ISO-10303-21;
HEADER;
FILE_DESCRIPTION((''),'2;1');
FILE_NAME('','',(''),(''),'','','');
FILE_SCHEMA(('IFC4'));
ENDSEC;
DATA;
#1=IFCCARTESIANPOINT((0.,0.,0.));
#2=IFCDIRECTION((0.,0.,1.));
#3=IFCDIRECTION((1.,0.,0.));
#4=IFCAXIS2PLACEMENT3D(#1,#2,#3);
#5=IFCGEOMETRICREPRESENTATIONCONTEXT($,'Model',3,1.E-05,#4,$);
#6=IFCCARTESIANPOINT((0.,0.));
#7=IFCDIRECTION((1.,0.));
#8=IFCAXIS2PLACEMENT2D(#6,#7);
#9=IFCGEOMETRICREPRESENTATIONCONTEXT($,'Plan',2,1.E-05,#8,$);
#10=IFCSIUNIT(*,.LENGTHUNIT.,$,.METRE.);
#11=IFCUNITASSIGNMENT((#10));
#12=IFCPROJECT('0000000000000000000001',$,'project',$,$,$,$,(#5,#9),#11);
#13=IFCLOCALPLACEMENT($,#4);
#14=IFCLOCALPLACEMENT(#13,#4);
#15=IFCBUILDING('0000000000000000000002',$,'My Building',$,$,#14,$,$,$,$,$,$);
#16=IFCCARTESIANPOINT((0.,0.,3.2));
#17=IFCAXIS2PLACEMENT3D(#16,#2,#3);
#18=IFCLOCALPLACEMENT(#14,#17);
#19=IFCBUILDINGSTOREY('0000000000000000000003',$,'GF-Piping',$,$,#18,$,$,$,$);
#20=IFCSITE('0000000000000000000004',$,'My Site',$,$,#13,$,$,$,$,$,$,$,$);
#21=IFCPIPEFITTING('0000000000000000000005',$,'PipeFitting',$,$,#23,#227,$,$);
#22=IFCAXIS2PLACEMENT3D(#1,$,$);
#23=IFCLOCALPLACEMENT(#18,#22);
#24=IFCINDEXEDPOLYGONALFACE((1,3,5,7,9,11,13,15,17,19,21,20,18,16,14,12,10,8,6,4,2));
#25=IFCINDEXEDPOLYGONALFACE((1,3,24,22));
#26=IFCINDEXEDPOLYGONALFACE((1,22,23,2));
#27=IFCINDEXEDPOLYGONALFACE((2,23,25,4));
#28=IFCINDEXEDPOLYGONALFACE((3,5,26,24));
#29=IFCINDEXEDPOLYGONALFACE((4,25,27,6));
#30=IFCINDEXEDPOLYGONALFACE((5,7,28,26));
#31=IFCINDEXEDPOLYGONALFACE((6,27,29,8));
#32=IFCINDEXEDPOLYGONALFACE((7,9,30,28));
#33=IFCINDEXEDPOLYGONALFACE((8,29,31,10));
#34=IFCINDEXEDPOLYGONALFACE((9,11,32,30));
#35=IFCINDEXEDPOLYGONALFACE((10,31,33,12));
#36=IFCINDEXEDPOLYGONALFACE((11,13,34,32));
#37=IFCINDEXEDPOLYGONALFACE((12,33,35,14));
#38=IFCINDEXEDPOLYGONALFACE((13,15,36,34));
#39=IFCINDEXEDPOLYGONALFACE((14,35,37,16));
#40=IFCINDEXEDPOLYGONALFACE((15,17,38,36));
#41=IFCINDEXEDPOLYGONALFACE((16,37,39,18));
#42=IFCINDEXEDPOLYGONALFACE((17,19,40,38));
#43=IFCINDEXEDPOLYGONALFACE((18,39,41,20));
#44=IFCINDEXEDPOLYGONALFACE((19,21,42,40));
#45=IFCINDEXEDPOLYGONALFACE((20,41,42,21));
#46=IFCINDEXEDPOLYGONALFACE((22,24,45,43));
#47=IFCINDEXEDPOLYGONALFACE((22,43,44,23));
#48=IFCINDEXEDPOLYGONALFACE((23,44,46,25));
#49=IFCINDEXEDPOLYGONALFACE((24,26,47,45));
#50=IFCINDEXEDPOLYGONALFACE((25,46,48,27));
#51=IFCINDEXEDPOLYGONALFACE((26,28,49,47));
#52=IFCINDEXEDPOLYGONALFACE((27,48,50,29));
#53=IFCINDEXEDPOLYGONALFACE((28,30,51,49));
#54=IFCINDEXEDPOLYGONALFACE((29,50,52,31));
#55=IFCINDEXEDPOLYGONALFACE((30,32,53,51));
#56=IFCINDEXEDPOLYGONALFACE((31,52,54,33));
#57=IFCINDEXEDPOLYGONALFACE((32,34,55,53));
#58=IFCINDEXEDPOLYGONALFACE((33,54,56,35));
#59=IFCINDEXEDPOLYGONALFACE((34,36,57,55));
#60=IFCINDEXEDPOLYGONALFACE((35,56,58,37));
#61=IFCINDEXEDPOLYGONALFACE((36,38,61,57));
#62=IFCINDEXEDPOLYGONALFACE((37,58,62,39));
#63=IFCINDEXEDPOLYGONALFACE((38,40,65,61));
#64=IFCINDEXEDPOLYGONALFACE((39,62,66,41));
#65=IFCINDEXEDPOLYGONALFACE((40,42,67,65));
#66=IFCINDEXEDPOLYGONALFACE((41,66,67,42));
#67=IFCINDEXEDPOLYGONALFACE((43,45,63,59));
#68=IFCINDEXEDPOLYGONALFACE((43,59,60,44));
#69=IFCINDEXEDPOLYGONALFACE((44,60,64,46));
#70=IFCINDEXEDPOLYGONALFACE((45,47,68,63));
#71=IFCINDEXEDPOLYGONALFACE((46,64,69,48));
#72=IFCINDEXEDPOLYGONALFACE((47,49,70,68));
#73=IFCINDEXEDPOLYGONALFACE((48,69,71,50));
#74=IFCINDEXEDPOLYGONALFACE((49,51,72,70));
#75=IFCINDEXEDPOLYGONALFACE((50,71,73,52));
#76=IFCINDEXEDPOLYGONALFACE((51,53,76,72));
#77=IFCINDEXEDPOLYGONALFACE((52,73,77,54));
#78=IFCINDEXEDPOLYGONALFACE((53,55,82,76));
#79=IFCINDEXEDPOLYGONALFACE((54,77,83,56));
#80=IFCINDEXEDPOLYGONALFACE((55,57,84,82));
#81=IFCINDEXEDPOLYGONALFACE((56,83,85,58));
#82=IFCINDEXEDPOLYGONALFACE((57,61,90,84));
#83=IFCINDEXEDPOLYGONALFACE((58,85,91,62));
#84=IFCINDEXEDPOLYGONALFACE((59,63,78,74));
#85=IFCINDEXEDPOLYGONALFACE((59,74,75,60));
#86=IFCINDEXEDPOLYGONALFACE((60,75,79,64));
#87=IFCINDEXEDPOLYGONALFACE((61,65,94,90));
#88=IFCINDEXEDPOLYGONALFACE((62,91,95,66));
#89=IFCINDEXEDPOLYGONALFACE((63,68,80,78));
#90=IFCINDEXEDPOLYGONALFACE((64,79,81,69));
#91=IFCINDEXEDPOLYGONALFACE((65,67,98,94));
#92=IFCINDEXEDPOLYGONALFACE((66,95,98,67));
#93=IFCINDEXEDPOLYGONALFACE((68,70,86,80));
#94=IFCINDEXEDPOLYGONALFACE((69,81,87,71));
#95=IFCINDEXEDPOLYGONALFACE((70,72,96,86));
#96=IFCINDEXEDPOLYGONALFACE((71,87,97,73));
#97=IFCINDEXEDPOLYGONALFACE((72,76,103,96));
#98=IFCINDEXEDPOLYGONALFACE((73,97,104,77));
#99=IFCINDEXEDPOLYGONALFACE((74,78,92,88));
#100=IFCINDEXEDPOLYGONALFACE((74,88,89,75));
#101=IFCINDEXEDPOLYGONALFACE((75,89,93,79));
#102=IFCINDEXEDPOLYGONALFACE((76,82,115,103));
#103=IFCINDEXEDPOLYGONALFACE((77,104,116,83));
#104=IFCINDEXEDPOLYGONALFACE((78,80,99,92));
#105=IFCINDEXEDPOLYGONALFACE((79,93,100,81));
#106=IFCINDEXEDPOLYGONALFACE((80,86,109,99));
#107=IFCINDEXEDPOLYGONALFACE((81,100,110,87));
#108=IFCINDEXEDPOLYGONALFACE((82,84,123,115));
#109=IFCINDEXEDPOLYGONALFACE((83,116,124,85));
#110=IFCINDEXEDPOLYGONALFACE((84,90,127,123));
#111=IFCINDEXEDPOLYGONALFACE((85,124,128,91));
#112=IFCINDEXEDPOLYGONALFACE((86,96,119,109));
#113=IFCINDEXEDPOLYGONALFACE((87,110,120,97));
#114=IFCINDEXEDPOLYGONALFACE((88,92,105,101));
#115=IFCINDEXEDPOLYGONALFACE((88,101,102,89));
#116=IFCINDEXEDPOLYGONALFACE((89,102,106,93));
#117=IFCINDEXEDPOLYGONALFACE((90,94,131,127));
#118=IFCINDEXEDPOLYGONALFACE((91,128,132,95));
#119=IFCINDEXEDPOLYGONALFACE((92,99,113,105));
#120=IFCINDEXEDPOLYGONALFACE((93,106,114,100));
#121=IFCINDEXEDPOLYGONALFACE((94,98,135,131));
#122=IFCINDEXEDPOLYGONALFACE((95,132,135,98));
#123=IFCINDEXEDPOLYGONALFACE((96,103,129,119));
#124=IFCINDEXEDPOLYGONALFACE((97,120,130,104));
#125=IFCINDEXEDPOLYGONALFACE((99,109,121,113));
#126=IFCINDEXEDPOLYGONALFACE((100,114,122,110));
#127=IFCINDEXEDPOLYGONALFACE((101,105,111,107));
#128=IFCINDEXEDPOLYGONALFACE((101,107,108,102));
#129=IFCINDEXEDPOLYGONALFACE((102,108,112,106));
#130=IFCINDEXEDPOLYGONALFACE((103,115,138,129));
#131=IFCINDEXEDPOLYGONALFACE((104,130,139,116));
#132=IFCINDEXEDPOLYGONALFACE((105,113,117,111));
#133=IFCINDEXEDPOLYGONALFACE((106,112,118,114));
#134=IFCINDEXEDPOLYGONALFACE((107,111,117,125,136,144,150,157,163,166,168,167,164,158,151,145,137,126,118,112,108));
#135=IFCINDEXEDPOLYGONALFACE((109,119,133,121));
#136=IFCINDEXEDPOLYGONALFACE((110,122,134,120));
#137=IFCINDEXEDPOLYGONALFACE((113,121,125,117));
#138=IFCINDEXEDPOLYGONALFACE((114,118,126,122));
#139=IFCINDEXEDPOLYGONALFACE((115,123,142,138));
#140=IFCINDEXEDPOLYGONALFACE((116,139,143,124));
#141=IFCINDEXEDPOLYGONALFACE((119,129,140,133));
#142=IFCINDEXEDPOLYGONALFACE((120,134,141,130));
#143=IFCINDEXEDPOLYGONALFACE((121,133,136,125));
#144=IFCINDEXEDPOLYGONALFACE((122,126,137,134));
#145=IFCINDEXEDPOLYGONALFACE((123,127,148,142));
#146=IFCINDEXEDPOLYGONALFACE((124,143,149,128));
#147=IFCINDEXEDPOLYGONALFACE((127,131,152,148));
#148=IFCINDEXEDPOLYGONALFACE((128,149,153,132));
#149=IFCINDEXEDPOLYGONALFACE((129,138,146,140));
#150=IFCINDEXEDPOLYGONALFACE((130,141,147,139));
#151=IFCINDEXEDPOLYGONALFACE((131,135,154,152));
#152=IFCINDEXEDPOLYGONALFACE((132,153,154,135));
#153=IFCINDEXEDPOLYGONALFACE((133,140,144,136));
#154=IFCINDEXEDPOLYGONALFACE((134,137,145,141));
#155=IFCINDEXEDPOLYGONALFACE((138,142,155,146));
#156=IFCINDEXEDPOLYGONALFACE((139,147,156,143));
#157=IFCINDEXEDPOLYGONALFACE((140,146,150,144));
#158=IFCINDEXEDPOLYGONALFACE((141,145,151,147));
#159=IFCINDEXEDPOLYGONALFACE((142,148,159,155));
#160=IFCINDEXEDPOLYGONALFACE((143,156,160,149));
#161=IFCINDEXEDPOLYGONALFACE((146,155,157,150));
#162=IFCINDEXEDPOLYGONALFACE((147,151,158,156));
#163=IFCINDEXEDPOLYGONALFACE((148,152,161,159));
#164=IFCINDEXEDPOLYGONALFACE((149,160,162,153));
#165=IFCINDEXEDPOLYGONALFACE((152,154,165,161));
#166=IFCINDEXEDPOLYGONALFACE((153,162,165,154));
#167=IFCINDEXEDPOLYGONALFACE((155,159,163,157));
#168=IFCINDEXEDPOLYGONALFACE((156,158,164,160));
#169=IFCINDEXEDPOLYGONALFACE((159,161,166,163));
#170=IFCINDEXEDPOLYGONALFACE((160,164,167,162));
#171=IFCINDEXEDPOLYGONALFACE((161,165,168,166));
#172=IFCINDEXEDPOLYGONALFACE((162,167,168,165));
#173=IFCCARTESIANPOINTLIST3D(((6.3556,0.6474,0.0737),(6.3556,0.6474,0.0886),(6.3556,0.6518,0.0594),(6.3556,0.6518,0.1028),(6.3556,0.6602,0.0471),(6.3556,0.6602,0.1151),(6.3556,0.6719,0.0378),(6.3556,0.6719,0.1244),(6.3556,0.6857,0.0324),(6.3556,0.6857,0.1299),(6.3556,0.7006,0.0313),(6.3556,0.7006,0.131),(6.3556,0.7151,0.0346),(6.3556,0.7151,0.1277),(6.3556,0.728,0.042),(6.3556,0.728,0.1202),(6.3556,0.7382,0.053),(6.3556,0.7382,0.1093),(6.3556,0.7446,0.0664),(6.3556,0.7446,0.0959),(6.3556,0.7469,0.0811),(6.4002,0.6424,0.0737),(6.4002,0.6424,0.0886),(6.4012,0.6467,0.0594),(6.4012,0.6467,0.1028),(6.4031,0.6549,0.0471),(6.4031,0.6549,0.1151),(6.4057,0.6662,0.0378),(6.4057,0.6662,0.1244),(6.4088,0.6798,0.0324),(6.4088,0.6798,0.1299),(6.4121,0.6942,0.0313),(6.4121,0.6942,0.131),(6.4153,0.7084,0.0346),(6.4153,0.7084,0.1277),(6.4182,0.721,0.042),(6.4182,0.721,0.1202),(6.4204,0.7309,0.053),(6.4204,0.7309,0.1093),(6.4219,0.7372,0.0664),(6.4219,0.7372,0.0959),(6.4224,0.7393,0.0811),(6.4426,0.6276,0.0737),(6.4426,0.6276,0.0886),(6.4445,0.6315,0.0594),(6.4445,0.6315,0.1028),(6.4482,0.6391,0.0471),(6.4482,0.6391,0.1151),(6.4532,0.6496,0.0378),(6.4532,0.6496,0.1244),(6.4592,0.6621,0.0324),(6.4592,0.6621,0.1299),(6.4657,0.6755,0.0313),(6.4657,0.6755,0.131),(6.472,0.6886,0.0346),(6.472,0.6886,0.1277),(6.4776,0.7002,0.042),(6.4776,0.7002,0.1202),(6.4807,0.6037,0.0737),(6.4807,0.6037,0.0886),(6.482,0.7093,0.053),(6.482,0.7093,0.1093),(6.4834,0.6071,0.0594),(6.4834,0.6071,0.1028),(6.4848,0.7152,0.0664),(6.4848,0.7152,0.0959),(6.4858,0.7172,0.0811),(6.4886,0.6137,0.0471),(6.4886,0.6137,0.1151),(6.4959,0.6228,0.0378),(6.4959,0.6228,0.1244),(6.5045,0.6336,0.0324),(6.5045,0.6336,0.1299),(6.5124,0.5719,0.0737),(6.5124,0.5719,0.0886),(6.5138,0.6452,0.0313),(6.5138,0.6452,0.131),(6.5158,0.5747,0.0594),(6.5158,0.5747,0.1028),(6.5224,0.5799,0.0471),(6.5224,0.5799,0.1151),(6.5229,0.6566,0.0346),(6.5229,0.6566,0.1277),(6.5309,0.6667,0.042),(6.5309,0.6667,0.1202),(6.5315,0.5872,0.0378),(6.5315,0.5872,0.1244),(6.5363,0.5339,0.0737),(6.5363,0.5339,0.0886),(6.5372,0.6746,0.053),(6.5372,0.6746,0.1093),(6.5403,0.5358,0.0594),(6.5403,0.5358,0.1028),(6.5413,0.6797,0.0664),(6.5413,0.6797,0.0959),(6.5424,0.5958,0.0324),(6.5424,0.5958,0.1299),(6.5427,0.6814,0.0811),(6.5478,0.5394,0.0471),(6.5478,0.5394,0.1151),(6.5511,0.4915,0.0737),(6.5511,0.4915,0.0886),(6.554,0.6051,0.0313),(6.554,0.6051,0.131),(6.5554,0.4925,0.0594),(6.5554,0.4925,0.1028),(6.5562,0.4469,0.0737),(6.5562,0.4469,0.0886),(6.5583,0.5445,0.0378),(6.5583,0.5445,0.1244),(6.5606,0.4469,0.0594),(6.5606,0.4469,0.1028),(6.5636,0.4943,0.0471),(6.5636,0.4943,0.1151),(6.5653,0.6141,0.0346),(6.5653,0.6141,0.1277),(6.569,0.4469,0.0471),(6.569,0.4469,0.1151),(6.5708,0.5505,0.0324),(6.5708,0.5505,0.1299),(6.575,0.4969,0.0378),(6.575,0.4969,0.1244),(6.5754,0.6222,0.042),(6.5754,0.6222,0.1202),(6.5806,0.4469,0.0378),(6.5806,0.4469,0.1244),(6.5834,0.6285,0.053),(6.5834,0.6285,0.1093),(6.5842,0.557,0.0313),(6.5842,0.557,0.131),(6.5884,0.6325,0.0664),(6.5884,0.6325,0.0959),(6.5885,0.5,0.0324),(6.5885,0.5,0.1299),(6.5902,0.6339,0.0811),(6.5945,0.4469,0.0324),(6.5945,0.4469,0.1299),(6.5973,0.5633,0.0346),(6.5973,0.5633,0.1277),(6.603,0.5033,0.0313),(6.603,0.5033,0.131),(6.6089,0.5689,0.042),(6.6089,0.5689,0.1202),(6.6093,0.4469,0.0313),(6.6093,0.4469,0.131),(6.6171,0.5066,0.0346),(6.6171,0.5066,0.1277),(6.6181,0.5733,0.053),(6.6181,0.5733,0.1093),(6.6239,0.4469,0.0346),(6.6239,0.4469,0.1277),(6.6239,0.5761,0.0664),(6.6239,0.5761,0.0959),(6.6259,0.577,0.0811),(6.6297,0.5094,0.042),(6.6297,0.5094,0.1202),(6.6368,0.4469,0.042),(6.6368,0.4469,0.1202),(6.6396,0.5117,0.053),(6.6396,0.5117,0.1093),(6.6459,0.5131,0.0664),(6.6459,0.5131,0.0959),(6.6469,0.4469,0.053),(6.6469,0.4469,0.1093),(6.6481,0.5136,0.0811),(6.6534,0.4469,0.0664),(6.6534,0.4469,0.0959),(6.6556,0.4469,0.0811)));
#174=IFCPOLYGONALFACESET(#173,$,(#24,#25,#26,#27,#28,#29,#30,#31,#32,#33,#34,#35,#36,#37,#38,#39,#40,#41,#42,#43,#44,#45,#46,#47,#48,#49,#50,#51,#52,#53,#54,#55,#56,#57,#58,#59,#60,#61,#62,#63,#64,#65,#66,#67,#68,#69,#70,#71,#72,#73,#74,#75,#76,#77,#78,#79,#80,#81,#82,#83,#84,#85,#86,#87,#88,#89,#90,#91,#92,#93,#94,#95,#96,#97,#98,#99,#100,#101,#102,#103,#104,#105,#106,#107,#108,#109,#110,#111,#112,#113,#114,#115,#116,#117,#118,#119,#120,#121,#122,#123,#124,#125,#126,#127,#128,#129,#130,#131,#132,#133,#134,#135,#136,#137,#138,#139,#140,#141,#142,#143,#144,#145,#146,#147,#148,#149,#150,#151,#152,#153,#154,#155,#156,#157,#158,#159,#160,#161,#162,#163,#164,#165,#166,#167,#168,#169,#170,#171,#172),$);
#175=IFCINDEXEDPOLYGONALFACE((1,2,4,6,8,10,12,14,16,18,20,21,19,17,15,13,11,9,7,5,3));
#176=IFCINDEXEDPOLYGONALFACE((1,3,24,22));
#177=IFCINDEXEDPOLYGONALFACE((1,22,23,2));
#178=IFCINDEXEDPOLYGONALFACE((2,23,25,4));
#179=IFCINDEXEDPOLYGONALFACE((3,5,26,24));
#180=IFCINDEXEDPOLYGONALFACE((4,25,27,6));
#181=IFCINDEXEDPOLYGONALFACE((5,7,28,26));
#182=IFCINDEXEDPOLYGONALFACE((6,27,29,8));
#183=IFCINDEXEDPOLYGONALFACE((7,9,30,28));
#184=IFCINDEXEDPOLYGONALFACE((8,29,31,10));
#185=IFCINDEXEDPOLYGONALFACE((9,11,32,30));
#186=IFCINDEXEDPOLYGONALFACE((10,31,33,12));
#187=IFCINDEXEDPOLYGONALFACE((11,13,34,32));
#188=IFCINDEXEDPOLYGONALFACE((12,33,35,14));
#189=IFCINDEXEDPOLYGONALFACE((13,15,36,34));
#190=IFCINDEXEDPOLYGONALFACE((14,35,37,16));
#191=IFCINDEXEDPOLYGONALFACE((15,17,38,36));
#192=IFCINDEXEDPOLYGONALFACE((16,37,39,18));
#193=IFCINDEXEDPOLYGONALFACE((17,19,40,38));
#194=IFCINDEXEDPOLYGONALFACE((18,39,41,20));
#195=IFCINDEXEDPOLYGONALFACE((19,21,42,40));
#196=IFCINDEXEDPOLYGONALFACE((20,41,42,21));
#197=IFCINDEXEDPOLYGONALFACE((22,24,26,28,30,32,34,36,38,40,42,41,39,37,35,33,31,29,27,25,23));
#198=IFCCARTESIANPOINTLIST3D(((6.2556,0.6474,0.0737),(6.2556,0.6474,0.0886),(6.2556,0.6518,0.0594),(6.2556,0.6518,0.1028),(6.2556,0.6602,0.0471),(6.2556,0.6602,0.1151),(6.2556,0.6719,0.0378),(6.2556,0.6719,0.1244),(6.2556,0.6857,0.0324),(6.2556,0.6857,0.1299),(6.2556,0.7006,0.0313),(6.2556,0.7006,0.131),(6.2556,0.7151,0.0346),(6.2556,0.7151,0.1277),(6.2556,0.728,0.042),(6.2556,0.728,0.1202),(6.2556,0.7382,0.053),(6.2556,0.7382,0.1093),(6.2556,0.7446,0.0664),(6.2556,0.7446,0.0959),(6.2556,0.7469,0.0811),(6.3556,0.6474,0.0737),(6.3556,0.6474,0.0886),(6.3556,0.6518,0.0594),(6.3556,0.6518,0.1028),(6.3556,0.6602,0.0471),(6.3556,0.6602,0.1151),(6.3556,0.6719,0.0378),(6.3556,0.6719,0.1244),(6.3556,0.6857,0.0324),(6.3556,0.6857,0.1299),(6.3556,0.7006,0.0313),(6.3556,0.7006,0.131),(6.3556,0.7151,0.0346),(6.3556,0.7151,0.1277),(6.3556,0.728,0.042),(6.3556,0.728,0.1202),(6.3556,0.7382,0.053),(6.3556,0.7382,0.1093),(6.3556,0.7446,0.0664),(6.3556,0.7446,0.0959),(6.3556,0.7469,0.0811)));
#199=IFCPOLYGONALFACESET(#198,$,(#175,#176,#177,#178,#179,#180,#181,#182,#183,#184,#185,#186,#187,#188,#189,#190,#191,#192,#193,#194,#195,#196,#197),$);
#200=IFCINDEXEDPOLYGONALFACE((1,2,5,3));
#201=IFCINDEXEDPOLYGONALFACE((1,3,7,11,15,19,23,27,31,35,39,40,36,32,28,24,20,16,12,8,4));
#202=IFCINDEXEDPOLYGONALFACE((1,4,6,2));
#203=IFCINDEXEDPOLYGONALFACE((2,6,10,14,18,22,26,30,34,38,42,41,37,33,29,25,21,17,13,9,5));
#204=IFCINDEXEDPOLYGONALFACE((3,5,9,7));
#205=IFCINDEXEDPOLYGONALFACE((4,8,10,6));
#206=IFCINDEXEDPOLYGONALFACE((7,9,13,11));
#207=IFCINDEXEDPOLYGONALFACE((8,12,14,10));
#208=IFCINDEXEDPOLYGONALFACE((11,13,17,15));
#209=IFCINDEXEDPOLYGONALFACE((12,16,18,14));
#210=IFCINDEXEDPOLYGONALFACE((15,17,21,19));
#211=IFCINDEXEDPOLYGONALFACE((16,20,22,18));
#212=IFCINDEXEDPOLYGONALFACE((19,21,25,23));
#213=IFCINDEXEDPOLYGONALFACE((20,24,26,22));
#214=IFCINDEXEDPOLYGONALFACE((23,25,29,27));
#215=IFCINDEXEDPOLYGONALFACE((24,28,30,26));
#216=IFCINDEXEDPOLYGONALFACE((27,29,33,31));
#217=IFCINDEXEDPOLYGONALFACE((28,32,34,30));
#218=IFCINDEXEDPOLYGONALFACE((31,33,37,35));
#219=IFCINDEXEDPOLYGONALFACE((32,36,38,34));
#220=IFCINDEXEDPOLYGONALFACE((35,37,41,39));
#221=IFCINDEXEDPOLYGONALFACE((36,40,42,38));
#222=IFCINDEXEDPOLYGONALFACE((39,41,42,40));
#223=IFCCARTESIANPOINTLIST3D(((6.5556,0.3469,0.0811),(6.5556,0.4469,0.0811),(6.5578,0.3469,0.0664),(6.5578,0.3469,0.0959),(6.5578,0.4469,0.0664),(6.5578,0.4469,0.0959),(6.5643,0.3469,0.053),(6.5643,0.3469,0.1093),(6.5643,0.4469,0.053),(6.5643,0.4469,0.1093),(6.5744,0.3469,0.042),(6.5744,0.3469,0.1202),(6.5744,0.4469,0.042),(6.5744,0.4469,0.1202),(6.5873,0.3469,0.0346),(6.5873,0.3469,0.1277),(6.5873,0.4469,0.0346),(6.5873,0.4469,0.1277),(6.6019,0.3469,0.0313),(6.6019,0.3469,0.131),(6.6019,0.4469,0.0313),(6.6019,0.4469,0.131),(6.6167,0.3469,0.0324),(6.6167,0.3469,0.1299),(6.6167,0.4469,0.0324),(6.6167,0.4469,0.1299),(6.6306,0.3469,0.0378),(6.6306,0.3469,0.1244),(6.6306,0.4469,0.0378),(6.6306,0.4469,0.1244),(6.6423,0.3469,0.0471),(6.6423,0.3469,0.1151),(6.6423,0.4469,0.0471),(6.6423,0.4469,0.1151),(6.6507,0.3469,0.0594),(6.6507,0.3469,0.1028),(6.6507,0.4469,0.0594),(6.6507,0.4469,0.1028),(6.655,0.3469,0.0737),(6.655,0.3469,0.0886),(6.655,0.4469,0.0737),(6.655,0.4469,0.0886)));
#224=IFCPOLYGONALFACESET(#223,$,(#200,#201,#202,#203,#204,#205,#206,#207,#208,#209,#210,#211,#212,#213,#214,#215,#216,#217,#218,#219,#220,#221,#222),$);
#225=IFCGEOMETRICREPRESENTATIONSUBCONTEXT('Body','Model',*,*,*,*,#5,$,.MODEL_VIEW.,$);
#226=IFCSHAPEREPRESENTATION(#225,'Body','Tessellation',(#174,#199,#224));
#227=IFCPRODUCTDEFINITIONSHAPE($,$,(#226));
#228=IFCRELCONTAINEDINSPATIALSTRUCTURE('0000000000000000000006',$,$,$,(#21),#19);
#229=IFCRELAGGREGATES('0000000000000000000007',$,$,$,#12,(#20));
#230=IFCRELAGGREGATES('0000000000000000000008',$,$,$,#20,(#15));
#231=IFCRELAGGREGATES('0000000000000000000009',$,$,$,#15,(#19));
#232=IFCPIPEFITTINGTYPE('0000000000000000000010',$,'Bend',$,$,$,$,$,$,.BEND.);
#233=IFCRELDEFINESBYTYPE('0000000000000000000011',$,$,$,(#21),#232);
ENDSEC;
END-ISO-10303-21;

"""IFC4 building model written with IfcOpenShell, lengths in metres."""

from ifc_helpers import new_model, entity, si_unit, frame, origin_with_axes, origin_2d_with_axis, place, context, subcontext, project, spatial, circle, extrude, source, transform, mapped, type_object, type_shapes, element, save


model = new_model("IFC4")

# Units and contexts
model_context = context("Model", 3, precision=1e-05, world=origin_with_axes())
plan_context = context("Plan", 2, precision=1e-05, world=origin_2d_with_axis())
body_context = subcontext(model_context, "Body", "Model", "MODEL_VIEW")
ifc_project = project(units=[si_unit("LENGTHUNIT", "METRE")], contexts=[model_context, plan_context])

# Site, building, storey
site_placement = place(None, origin_with_axes())
site = spatial("IfcSite", under=ifc_project, at=site_placement, Name="My Site")
building_placement = place(site_placement, origin_with_axes())
building = spatial("IfcBuilding", under=site, at=building_placement, Name="My Building")
storey_placement = place(building_placement, frame((0.0, 0.0, 3.2), z_axis=(0.0, 0.0, 1.0), x_axis=(1.0, 0.0, 0.0)))
storey = spatial("IfcBuildingStorey", under=building, at=storey_placement, Name="GF-Piping")

# Pipe fitting
pipe_fitting_type = type_object("IfcPipeFittingType", Name="Bend", PredefinedType="BEND")
shared_shape = source(origin_with_axes(), body_context, "Body", "SolidModel", [
    entity("IfcSweptDiskSolid", entity("IfcIndexedPolyCurve", entity("IfcCartesianPointList3D", [[0.0, 0.0, 0.1], [-0.0732, 0.0, 0.2768], [-0.25, 0.0, 0.35]]), [entity("IfcArcIndex", [1, 2, 3])]), 0.05),
    extrude(circle(Radius=0.05), origin_with_axes(), (0.0, 0.0, 1.0), 0.1),
    extrude(circle(Radius=0.05), frame((-0.25, 0.0, 0.35), z_axis=(-1.0, 0.0, 0.0), x_axis=(0.0, 0.0, -1.0)), (0.0, 0.0, 1.0), 0.1),
])
type_shapes(pipe_fitting_type, [shared_shape])
for number, where, z_axis, x_axis, name in (
    (1, (6.2556, 0.6969, 0.0811), (1.0, 0.0, 0.0), (0.0, 1.0, 0.0), "PipeFitting"),
):
    element("IfcPipeFitting", number, at=place(storey_placement, frame(where, z_axis=z_axis, x_axis=x_axis)), inside=storey, type_object=pipe_fitting_type, Name=name, context=body_context, shape_type="MappedRepresentation", body=[
        mapped(shared_shape, transform((0.0, 0.0, 0.0), x_axis=(1.0, 0.0, 0.0), y_axis=(0.0, 1.0, 0.0), z_axis=(0.0, 0.0, 1.0), scale=1.0)),
    ])

save(model, "model.ifc")
